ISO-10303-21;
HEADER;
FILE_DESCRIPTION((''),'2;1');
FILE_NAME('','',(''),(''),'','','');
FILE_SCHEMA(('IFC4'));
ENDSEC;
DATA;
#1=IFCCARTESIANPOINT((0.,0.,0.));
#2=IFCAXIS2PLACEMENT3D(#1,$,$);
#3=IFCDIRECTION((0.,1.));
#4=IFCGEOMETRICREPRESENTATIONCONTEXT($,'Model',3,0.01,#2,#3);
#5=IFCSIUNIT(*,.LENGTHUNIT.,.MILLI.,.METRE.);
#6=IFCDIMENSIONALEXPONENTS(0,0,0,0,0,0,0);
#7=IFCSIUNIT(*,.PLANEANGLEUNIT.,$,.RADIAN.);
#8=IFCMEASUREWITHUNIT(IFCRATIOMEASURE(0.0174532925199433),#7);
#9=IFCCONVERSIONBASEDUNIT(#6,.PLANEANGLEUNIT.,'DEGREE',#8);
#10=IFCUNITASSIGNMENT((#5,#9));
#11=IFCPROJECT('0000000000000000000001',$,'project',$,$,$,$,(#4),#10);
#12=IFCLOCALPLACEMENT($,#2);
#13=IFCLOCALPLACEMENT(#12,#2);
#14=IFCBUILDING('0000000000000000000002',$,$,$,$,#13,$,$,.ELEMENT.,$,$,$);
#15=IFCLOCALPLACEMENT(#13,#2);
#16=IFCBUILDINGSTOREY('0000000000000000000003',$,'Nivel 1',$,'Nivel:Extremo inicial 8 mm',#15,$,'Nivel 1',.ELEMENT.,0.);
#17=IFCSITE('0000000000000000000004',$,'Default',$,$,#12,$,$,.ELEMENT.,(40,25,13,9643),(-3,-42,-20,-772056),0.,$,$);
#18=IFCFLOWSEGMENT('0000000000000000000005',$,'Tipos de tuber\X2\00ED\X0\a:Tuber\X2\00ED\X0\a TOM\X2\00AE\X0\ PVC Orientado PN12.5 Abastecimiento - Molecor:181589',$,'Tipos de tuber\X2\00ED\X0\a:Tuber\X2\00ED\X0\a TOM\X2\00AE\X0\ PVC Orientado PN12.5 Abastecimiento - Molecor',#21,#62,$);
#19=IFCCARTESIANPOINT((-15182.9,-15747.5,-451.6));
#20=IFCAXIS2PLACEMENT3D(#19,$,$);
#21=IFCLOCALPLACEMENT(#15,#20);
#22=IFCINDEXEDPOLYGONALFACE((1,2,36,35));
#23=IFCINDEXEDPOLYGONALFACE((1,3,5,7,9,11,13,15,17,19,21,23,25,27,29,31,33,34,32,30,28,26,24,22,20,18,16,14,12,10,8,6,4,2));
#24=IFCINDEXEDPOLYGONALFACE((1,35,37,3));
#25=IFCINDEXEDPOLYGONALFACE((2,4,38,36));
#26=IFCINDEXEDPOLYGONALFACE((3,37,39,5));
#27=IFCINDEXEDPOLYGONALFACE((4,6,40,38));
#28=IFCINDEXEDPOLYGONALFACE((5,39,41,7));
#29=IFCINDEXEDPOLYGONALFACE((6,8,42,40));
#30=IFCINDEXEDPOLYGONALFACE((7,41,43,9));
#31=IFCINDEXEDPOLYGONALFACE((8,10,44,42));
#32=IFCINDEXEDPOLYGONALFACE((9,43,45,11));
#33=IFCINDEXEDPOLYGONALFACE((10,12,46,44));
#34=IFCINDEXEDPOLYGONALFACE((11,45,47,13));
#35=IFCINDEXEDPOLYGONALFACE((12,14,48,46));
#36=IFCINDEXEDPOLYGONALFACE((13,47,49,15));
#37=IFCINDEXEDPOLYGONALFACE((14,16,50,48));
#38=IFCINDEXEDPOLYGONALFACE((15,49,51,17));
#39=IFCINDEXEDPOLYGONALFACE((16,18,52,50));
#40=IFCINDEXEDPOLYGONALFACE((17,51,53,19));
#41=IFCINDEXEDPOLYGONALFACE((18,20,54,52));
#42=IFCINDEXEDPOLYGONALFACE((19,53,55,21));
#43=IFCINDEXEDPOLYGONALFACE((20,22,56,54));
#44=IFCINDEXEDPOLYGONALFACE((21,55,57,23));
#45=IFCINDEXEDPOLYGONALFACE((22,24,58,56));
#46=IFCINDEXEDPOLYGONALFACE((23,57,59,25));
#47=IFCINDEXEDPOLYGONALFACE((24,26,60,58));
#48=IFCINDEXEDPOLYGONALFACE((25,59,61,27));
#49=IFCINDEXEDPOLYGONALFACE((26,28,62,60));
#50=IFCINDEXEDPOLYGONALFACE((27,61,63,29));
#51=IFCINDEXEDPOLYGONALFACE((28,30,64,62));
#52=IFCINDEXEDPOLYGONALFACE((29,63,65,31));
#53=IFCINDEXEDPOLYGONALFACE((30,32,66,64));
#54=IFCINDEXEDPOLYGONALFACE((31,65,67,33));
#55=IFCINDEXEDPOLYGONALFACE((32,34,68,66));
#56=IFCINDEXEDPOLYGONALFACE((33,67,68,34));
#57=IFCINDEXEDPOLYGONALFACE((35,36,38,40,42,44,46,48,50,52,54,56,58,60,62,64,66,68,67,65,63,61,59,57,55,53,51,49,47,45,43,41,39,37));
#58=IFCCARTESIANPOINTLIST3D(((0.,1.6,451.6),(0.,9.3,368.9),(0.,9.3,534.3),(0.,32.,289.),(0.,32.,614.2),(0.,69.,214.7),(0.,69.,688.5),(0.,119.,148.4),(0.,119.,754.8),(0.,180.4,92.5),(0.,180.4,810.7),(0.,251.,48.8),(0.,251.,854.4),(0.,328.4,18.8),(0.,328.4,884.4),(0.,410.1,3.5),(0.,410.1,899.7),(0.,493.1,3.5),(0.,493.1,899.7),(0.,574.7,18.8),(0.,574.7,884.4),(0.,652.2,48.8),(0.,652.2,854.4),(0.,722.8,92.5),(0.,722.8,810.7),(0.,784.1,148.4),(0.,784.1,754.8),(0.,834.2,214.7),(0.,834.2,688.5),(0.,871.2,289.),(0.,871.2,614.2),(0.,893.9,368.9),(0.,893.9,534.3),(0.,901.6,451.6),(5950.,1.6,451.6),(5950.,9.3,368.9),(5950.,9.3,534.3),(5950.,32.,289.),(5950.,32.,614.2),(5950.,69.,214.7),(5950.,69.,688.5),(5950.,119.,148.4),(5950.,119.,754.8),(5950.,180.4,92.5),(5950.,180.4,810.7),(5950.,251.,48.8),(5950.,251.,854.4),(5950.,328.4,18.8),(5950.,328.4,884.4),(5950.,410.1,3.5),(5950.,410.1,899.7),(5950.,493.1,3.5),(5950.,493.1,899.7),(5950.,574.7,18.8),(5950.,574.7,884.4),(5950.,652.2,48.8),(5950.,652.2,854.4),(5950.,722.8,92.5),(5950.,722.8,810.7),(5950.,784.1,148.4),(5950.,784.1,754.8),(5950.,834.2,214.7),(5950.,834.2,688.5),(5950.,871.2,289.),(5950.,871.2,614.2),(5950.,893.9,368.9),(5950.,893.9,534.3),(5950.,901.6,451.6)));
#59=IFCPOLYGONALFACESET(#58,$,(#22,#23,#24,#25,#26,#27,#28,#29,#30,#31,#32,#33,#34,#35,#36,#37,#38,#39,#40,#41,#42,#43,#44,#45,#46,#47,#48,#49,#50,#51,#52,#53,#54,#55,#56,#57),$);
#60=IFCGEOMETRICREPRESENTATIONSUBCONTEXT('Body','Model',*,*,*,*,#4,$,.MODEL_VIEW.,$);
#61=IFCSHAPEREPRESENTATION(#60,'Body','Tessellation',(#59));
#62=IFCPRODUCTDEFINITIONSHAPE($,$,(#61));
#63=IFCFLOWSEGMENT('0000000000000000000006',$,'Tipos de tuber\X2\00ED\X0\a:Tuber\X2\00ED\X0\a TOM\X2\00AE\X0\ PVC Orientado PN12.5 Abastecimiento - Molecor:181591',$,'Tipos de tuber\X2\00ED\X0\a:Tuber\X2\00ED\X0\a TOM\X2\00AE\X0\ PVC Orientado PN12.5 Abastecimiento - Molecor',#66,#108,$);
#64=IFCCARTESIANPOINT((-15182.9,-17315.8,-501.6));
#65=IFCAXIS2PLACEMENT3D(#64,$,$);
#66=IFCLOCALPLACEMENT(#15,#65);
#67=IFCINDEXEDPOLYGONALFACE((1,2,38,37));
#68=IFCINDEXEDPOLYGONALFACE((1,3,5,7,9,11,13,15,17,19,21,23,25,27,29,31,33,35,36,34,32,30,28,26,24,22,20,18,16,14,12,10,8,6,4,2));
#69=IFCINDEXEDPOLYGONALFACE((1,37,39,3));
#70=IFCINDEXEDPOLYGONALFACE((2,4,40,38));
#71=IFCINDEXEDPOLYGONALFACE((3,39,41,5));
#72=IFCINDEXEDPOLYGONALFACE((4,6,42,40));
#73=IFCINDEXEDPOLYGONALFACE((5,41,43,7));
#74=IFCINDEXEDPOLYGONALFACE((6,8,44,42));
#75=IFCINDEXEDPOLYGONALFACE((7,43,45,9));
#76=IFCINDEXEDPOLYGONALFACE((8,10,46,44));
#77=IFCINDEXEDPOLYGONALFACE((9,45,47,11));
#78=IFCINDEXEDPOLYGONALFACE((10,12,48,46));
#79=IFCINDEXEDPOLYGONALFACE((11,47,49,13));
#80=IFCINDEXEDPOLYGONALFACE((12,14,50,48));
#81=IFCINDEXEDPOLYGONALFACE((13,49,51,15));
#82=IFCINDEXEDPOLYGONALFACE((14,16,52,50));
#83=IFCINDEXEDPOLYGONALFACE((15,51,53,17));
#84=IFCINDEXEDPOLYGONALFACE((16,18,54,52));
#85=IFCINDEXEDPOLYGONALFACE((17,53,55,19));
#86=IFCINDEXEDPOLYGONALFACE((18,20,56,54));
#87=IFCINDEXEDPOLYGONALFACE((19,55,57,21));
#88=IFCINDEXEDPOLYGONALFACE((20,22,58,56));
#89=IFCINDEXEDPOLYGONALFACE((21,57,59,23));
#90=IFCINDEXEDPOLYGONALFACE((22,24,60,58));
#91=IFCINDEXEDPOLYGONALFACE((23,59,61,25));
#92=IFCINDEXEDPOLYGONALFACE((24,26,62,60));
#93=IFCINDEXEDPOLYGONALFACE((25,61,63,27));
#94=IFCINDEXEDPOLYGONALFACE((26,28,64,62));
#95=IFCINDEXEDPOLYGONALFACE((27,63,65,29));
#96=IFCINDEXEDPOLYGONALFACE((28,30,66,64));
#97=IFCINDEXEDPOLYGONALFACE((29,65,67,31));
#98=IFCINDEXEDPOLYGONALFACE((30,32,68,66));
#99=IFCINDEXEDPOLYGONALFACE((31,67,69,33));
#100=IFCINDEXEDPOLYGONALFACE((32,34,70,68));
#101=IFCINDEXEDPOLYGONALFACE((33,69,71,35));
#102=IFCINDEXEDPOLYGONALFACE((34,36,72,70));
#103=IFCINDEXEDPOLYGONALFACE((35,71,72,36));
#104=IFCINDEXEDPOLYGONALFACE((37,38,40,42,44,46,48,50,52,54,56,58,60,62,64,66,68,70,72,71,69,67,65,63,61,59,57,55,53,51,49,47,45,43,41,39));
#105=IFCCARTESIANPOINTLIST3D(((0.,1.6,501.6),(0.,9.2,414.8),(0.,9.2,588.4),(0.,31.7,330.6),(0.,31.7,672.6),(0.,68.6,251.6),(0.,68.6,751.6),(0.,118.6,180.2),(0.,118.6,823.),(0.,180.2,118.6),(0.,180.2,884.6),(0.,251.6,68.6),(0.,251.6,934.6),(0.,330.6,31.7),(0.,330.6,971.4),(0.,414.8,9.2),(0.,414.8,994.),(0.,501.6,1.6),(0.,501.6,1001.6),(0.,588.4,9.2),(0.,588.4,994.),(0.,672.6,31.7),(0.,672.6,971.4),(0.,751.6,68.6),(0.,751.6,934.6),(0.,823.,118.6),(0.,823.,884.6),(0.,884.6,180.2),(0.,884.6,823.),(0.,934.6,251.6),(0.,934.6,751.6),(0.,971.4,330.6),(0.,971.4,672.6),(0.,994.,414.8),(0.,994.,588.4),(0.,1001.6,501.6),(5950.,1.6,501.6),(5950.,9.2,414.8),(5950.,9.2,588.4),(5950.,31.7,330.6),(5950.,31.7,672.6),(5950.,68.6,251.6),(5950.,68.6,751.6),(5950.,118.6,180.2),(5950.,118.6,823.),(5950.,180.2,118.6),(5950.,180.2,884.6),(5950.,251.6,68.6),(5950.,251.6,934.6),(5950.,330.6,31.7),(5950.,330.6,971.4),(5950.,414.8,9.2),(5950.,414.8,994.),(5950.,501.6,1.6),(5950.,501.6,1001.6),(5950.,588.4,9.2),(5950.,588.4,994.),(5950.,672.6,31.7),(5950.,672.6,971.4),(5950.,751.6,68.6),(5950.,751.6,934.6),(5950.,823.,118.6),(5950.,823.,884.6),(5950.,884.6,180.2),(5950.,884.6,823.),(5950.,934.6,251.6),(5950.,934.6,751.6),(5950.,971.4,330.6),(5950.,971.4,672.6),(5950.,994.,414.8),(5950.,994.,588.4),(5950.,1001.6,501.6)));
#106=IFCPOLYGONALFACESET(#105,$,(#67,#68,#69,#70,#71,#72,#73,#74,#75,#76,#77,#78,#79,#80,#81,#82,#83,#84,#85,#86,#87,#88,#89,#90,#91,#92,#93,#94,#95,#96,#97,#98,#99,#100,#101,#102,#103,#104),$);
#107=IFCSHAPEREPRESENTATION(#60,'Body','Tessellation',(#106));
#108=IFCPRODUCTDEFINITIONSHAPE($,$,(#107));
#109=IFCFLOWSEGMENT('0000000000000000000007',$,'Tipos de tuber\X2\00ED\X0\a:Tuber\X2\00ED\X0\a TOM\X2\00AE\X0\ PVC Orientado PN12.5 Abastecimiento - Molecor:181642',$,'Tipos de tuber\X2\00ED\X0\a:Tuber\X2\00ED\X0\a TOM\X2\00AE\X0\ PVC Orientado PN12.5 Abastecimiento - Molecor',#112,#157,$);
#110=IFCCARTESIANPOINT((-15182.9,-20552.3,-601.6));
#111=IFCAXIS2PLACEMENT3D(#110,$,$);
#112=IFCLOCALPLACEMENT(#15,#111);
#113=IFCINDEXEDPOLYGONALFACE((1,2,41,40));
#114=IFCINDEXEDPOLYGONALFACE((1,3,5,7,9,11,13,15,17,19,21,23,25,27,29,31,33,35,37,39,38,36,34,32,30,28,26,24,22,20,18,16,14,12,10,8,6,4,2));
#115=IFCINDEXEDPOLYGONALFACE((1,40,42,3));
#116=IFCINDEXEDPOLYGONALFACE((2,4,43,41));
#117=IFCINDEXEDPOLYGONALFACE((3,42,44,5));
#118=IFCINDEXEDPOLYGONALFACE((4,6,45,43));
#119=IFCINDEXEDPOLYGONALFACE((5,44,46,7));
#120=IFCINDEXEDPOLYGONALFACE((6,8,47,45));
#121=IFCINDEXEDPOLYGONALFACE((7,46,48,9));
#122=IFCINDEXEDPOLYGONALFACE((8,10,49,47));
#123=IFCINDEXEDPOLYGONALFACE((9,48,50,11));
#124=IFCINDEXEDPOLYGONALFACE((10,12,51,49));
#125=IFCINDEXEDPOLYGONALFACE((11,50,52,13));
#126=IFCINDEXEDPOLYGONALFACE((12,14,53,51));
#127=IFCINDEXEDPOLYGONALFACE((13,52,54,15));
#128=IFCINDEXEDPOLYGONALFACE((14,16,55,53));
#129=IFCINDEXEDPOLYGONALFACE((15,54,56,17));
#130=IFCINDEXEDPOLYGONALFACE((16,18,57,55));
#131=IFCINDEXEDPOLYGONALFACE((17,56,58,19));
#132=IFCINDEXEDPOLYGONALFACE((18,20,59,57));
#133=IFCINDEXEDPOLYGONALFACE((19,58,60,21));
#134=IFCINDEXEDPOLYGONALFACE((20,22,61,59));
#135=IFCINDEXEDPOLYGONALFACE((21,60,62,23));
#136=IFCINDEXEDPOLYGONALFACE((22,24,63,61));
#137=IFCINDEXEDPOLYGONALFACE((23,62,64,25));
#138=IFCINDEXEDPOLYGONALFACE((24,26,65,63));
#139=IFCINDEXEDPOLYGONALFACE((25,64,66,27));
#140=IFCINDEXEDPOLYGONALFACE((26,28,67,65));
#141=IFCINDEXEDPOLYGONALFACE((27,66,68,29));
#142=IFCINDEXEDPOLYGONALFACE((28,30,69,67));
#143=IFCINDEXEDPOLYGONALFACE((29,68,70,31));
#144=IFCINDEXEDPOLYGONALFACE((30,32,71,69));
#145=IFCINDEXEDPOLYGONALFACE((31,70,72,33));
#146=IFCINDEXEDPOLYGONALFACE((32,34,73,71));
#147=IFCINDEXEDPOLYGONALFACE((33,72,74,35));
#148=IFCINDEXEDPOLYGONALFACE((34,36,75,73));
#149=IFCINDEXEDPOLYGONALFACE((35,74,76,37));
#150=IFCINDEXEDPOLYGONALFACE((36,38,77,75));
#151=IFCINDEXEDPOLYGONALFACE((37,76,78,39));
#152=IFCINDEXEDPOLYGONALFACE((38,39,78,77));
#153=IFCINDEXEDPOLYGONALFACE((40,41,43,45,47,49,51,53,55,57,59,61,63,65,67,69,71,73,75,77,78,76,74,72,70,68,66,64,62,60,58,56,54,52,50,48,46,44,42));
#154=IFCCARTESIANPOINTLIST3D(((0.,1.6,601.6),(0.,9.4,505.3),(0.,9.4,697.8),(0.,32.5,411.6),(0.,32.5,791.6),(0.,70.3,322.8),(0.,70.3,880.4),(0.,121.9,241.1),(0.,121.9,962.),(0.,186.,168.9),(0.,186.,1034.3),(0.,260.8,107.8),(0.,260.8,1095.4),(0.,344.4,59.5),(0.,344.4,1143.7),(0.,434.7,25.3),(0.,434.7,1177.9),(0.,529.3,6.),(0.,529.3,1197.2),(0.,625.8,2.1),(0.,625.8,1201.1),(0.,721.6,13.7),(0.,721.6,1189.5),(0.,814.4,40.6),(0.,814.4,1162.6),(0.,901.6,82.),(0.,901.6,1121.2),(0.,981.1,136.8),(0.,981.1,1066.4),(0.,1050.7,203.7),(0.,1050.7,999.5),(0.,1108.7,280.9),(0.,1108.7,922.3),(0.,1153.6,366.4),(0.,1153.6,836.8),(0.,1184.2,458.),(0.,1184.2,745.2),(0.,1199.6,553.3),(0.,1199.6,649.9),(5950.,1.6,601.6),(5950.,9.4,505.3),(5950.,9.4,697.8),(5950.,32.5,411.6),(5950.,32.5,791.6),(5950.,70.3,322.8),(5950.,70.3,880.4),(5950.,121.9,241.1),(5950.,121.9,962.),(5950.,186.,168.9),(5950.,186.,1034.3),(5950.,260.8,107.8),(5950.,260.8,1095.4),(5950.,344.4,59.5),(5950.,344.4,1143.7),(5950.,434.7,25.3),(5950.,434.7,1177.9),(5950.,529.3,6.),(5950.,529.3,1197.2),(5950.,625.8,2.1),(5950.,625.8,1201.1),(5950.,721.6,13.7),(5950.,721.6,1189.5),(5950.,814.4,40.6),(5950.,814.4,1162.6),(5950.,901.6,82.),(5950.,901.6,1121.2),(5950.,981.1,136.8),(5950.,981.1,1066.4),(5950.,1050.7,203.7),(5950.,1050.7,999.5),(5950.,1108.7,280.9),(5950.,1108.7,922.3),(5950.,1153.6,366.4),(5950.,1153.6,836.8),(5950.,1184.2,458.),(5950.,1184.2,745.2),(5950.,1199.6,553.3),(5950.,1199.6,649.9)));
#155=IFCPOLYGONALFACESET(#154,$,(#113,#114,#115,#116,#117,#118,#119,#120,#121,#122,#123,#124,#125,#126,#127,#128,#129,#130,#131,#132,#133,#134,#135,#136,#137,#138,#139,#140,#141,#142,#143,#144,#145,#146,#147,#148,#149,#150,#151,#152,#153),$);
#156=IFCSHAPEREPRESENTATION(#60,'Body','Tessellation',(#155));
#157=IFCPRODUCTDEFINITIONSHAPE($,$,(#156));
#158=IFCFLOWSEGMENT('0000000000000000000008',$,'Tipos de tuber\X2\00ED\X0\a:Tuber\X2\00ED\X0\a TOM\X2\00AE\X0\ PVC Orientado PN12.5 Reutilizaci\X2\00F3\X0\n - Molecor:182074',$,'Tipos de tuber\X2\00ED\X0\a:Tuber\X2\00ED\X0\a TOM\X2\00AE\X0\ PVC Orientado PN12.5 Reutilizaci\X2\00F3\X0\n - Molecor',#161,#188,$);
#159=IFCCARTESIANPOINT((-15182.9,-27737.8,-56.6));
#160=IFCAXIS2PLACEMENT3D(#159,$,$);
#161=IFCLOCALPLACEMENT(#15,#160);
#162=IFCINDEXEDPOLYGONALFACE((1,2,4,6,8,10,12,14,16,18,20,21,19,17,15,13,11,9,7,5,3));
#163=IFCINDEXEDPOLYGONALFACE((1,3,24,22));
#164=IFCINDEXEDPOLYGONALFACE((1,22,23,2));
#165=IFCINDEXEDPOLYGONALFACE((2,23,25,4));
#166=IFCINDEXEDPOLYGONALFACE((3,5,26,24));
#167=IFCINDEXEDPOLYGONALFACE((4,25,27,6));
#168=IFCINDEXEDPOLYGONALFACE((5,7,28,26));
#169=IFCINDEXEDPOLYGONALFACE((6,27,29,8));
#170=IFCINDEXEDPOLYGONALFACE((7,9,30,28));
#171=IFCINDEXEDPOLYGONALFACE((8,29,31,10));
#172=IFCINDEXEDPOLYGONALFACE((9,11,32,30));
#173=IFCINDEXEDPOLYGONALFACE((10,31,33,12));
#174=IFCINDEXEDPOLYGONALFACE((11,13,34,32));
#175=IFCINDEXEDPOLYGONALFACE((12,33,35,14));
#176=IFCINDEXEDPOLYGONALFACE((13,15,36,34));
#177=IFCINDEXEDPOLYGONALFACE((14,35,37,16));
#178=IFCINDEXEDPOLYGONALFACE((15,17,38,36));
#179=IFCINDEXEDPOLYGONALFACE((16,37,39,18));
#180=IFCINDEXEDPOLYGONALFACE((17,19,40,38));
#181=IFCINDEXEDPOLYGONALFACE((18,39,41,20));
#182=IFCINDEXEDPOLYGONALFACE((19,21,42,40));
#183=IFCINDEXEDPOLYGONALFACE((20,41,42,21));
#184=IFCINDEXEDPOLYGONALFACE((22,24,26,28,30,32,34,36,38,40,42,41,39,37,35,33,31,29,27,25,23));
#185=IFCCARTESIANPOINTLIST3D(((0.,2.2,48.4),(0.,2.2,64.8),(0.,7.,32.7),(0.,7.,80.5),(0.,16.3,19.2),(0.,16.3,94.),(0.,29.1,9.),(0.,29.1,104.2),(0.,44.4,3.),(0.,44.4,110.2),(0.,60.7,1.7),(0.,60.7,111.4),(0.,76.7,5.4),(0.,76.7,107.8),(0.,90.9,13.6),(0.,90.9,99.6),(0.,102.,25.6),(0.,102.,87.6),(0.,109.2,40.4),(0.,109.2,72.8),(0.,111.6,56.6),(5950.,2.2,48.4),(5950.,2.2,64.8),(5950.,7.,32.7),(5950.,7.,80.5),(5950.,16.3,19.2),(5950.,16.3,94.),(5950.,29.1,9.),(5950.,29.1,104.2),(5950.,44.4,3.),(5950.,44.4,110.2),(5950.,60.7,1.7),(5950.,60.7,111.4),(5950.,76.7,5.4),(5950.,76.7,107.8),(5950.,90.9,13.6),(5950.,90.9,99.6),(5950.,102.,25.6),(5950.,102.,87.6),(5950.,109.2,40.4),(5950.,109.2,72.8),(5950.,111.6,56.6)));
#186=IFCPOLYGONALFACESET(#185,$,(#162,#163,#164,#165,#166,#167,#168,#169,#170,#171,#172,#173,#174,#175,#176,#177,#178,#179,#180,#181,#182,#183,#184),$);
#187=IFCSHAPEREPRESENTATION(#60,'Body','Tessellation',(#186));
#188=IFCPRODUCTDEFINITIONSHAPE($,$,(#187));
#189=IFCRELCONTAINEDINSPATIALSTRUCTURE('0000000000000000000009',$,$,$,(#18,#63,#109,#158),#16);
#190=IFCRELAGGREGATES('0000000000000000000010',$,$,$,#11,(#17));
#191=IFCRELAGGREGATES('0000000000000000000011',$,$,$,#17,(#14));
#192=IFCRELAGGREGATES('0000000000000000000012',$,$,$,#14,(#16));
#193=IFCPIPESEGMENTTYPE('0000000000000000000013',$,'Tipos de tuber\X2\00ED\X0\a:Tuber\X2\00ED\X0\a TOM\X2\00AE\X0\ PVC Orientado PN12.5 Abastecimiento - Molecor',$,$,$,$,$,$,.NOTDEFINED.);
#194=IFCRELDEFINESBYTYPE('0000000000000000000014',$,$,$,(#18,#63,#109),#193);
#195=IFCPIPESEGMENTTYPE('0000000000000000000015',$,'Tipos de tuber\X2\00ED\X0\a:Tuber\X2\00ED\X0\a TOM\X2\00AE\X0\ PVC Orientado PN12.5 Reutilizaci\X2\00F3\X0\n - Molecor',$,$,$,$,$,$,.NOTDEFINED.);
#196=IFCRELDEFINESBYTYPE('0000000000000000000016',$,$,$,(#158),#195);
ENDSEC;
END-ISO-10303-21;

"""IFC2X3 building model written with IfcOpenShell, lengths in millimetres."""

from ifc_helpers import new_model, entity, si_unit, converted_unit, direction, frame, frame_2d, origin, place, context, subcontext, project, spatial, circle, extrude, type_object, element, save


model = new_model("IFC2X3")

# Units and contexts
model_context = context("Model", 3, precision=0.01, world=origin(), true_north=direction((0.0, 1.0)))
body_context = subcontext(model_context, "Body", "Model", "MODEL_VIEW")
ifc_project = project(units=[si_unit("LENGTHUNIT", "METRE", prefix="MILLI"), converted_unit("PLANEANGLEUNIT", "DEGREE", entity("IfcRatioMeasure", 0.0174532925199433), si_unit("PLANEANGLEUNIT", "RADIAN"), dimensions=[0, 0, 0, 0, 0, 0, 0])], contexts=[model_context])

# Site, building, storey
site_placement = place(None, origin())
site = spatial("IfcSite", under=ifc_project, at=site_placement, Name="Default", CompositionType="ELEMENT", RefLatitude=(40, 25, 13, 9643), RefLongitude=(-3, -42, -20, -772056), RefElevation=0.0)
building_placement = place(site_placement, origin())
building = spatial("IfcBuilding", under=site, at=building_placement, CompositionType="ELEMENT")
storey_placement = place(building_placement, origin())
storey = spatial("IfcBuildingStorey", under=building, at=storey_placement, Name="Nivel 1", ObjectType="Nivel:Extremo inicial 8 mm", LongName="Nivel 1", CompositionType="ELEMENT", Elevation=0.0)

# Flow segments
pipe_segment_type_1 = type_object("IfcPipeSegmentType", Name="Tipos de tubería:Tubería TOM® PVC Orientado PN12.5 Abastecimiento - Molecor", PredefinedType="NOTDEFINED")
flow_segment_1_placement = place(storey_placement, frame((-15182.9, -15747.5, -451.6)))
element("IfcFlowSegment", 1, at=flow_segment_1_placement, inside=storey, type_object=pipe_segment_type_1, Name="Tipos de tubería:Tubería TOM® PVC Orientado PN12.5 Abastecimiento - Molecor:181589", ObjectType="Tipos de tubería:Tubería TOM® PVC Orientado PN12.5 Abastecimiento - Molecor", context=body_context, shape_type="SweptSolid", body=[
    extrude(circle(Radius=450.0, at=frame_2d((0.0, 0.0), x_axis=(1.0, 0.0))), frame((0.0, 451.6, 451.6), z_axis=(1.0, 0.0, 0.0), x_axis=(0.0, -1.0, 0.0)), (0.0, 0.0, 1.0), 5950.0),
])
flow_segment_2_placement = place(storey_placement, frame((-15182.9, -17315.8, -501.6)))
element("IfcFlowSegment", 2, at=flow_segment_2_placement, inside=storey, type_object=pipe_segment_type_1, Name="Tipos de tubería:Tubería TOM® PVC Orientado PN12.5 Abastecimiento - Molecor:181591", ObjectType="Tipos de tubería:Tubería TOM® PVC Orientado PN12.5 Abastecimiento - Molecor", context=body_context, shape_type="SweptSolid", body=[
    extrude(circle(Radius=500.0, at=frame_2d((0.0, 0.0), x_axis=(1.0, 0.0))), frame((0.0, 501.6, 501.6), z_axis=(1.0, 0.0, 0.0), x_axis=(0.0, -1.0, 0.0)), (0.0, 0.0, 1.0), 5950.0),
])
flow_segment_3_placement = place(storey_placement, frame((-15182.9, -20552.3, -601.6)))
element("IfcFlowSegment", 3, at=flow_segment_3_placement, inside=storey, type_object=pipe_segment_type_1, Name="Tipos de tubería:Tubería TOM® PVC Orientado PN12.5 Abastecimiento - Molecor:181642", ObjectType="Tipos de tubería:Tubería TOM® PVC Orientado PN12.5 Abastecimiento - Molecor", context=body_context, shape_type="SweptSolid", body=[
    extrude(circle(Radius=600.0, at=frame_2d((0.0, 0.0), x_axis=(1.0, 0.0))), frame((0.0, 601.6, 601.6), z_axis=(1.0, 0.0, 0.0), x_axis=(0.0, -1.0, 0.0)), (0.0, 0.0, 1.0), 5950.0),
])
pipe_segment_type_2 = type_object("IfcPipeSegmentType", Name="Tipos de tubería:Tubería TOM® PVC Orientado PN12.5 Reutilización - Molecor", PredefinedType="NOTDEFINED")
flow_segment_4_placement = place(storey_placement, frame((-15182.9, -27737.8, -56.6)))
element("IfcFlowSegment", 4, at=flow_segment_4_placement, inside=storey, type_object=pipe_segment_type_2, Name="Tipos de tubería:Tubería TOM® PVC Orientado PN12.5 Reutilización - Molecor:182074", ObjectType="Tipos de tubería:Tubería TOM® PVC Orientado PN12.5 Reutilización - Molecor", context=body_context, shape_type="SweptSolid", body=[
    extrude(circle(Radius=55.0, at=frame_2d((0.0, 0.0), x_axis=(1.0, 0.0))), frame((0.0, 56.6, 56.6), z_axis=(1.0, 0.0, 0.0), x_axis=(0.0, 1.0, 0.0)), (0.0, 0.0, 1.0), 5950.0),
])

save(model, "model.ifc")
